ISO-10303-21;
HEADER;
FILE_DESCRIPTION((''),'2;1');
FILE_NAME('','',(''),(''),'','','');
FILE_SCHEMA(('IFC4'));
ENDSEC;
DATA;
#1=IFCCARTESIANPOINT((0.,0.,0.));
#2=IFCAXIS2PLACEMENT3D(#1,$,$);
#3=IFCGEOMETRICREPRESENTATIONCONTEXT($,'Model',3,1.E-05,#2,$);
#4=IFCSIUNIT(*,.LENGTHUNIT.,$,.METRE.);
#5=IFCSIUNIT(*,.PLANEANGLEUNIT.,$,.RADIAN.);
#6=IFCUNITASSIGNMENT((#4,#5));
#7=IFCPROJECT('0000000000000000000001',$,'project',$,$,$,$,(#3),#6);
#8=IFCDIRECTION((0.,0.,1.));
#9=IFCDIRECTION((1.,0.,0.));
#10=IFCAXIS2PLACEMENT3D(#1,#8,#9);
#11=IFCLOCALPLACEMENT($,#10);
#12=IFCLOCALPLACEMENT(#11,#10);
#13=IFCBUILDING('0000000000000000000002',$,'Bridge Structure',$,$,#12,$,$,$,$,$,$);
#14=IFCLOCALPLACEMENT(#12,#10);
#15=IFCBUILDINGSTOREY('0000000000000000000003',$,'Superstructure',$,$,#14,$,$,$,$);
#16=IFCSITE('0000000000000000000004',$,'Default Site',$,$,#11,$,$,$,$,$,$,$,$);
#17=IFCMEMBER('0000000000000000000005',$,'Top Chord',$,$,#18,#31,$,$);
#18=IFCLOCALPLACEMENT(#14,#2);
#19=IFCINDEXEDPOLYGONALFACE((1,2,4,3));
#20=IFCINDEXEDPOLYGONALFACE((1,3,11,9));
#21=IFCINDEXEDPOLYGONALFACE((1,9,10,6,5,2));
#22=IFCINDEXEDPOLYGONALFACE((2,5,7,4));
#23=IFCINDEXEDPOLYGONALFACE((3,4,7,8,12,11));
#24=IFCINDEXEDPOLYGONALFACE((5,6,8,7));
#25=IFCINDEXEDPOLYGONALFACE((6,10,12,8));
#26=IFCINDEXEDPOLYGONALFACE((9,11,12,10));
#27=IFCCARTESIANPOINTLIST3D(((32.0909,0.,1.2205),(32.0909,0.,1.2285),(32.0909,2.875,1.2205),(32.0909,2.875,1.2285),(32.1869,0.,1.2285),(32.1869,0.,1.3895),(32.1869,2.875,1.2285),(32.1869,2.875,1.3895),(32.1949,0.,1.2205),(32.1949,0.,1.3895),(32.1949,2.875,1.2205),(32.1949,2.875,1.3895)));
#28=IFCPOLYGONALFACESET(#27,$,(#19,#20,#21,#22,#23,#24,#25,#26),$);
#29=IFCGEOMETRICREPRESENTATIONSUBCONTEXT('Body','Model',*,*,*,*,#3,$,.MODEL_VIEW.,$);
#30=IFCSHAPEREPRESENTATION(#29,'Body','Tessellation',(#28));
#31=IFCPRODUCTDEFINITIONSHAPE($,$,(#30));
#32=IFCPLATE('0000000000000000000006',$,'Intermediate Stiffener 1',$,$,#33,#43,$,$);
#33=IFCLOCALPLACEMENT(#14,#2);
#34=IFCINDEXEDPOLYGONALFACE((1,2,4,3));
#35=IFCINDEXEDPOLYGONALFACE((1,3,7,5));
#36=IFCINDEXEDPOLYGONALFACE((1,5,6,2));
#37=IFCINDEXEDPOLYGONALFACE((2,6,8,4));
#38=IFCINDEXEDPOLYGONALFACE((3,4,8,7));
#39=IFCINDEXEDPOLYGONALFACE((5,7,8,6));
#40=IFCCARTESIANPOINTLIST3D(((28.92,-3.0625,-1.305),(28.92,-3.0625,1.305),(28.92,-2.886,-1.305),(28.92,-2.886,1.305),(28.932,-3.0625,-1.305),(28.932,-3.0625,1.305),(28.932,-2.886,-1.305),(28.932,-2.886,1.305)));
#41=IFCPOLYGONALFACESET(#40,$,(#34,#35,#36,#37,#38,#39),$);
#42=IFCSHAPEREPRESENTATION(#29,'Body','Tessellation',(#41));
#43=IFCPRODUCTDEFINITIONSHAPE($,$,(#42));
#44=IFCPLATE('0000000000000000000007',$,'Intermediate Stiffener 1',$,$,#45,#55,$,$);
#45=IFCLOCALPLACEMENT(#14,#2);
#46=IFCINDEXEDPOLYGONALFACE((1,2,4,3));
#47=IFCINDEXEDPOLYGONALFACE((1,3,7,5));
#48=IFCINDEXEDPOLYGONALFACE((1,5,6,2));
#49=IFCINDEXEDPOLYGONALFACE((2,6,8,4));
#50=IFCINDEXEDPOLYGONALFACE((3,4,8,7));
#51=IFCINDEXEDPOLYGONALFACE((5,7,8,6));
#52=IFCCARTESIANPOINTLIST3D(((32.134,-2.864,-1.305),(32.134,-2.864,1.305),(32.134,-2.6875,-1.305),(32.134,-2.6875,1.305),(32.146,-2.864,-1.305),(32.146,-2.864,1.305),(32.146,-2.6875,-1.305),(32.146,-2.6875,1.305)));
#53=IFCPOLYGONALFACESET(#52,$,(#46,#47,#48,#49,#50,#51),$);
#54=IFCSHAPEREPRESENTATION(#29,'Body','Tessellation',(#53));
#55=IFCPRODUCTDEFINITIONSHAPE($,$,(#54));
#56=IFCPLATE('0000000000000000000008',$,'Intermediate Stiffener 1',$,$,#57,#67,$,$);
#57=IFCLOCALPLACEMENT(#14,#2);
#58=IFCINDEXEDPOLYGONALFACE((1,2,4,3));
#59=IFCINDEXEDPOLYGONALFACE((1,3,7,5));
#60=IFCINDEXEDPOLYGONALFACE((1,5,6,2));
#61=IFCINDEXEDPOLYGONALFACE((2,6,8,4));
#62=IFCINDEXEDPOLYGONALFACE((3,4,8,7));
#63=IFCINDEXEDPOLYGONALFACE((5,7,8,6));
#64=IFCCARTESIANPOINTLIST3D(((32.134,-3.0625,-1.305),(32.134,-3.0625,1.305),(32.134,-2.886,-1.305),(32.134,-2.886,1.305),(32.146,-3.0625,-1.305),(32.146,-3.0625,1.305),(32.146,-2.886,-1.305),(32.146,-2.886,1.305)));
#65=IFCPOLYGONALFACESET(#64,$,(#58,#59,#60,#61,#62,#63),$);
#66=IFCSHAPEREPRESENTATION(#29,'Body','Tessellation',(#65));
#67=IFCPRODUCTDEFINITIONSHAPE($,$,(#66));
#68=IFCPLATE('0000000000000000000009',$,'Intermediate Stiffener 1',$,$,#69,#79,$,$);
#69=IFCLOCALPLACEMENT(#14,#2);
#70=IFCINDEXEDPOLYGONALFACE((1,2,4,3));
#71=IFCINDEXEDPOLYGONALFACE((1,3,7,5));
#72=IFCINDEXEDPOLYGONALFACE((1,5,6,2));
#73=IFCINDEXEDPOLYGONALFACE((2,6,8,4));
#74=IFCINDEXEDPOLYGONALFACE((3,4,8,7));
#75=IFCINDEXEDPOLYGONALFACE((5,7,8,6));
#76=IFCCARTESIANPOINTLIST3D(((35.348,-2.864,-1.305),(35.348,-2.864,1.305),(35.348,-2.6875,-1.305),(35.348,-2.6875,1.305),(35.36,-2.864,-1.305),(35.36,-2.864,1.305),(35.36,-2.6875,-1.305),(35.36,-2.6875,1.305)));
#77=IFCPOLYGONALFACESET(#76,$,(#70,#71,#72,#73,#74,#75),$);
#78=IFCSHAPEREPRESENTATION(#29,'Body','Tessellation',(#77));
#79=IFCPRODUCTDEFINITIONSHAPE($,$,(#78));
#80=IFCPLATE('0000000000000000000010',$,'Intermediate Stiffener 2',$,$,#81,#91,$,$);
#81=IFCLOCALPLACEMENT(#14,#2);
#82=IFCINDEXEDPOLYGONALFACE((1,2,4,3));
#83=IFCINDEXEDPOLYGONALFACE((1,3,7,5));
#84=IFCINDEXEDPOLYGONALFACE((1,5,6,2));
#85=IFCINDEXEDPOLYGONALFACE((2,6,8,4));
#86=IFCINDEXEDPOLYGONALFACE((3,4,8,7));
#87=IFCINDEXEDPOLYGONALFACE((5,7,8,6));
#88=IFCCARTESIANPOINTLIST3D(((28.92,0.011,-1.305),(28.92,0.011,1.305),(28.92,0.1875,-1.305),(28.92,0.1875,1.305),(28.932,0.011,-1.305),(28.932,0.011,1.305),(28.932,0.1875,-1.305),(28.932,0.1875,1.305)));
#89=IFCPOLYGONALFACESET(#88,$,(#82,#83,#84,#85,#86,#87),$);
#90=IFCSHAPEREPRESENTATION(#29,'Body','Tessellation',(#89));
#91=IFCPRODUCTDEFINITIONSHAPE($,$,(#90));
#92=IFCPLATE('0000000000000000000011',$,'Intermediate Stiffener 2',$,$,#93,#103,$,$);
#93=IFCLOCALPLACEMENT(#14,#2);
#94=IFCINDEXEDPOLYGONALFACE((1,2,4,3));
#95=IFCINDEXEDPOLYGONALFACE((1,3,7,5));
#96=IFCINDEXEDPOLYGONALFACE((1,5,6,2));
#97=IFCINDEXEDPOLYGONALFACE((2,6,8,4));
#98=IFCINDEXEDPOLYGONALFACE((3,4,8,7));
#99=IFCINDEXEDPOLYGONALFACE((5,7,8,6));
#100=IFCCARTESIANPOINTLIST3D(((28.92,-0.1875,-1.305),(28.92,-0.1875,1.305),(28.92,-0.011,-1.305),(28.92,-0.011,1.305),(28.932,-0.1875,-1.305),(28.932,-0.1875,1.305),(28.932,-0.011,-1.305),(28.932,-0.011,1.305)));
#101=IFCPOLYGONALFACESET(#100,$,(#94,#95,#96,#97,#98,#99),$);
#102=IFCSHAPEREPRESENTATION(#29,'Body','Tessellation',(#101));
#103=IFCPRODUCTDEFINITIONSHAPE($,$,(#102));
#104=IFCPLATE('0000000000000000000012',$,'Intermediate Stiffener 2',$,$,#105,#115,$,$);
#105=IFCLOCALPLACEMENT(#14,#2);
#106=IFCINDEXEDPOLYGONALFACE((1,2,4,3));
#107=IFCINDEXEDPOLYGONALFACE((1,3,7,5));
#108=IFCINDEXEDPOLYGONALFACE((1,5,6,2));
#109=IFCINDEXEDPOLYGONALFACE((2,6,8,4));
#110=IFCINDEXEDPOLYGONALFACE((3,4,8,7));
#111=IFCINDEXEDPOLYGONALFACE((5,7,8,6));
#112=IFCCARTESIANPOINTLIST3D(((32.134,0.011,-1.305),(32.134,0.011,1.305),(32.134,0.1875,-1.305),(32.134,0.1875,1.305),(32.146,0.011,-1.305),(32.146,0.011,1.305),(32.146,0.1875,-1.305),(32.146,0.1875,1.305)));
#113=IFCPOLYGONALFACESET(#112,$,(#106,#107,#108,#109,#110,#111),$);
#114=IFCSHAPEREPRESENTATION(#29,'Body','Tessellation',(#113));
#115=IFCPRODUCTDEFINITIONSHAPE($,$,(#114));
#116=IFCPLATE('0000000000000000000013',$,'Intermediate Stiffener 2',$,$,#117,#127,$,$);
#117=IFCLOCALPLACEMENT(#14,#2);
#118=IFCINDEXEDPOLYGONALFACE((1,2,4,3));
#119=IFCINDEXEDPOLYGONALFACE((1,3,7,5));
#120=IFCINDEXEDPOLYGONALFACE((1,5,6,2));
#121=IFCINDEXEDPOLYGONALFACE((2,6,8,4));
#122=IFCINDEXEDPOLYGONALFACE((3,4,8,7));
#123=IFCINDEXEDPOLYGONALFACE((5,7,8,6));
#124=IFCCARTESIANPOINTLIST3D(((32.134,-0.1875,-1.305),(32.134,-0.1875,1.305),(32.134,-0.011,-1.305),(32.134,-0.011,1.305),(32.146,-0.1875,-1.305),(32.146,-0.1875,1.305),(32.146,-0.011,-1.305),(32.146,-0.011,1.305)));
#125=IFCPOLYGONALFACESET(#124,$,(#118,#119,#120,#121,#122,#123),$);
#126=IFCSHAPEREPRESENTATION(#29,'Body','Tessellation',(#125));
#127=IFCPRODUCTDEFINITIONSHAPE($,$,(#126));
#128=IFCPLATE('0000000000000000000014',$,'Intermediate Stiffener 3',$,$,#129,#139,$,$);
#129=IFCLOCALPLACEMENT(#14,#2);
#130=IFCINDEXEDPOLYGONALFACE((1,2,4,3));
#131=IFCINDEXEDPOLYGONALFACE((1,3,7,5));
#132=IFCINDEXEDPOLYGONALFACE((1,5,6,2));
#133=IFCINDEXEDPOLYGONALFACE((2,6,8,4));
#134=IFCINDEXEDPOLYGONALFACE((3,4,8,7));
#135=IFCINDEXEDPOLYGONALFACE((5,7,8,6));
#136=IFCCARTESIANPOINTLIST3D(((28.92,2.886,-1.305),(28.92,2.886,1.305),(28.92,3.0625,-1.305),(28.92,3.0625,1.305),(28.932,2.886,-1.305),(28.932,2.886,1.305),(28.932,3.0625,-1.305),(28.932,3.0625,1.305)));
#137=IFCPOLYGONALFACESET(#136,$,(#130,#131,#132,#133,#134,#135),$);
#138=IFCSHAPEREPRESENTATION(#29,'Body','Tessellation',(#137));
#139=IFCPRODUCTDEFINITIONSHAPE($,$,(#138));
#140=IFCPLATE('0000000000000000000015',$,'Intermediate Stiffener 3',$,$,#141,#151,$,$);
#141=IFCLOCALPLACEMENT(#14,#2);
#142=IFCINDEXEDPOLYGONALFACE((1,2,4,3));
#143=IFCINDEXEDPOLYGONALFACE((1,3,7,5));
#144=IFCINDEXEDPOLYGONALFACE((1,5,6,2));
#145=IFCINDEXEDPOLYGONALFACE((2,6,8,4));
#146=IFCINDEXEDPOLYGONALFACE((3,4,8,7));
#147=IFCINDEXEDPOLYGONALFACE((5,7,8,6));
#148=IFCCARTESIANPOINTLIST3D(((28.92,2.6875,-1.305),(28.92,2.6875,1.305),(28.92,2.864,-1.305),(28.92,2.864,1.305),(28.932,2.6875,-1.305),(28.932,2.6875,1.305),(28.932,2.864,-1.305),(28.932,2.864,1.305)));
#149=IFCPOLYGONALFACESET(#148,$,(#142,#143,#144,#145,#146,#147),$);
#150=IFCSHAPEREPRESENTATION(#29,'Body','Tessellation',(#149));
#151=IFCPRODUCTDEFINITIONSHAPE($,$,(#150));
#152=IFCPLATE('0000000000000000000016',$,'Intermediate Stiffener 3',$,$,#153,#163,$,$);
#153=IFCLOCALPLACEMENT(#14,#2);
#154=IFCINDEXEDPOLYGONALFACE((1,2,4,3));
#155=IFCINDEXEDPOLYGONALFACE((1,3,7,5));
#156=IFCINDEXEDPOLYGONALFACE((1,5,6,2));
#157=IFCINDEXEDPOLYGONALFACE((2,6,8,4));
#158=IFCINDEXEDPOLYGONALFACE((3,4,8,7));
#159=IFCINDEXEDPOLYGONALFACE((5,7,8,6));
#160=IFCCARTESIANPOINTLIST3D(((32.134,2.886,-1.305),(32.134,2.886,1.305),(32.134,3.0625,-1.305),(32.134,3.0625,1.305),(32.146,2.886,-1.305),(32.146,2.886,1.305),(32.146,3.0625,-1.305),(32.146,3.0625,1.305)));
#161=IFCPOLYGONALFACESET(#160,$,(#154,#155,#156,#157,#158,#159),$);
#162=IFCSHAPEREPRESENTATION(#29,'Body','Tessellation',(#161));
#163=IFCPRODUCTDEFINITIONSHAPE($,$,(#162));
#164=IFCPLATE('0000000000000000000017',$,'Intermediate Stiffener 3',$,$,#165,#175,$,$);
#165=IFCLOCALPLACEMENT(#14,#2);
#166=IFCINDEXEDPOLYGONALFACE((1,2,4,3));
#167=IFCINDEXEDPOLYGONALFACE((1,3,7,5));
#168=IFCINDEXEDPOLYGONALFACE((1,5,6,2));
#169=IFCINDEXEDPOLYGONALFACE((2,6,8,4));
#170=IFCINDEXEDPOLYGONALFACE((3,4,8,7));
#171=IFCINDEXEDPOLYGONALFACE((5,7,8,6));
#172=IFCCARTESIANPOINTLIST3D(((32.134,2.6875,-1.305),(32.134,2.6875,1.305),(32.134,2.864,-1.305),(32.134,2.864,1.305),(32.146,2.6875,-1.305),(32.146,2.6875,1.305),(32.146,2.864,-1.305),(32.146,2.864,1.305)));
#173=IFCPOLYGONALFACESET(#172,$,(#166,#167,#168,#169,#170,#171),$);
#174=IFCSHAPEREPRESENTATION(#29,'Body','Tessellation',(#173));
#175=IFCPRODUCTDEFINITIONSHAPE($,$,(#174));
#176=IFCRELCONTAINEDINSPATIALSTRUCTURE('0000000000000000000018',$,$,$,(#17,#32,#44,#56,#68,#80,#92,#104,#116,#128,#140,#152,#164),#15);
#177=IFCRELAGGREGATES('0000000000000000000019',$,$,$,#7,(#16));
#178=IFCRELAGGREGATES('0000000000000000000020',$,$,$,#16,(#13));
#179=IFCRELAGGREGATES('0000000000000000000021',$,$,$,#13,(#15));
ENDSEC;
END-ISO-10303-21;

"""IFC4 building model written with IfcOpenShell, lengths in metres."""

from ifc_helpers import new_model, si_unit, frame, origin, origin_with_axes, origin_2d_with_axis, place, context, subcontext, project, spatial, rectangle, l_section, extrude, element, save


model = new_model("IFC4")

# Units and contexts
model_context = context("Model", 3, precision=1e-05, world=origin())
body_context = subcontext(model_context, "Body", "Model", "MODEL_VIEW")
ifc_project = project(units=[si_unit("LENGTHUNIT", "METRE"), si_unit("PLANEANGLEUNIT", "RADIAN")], contexts=[model_context])

# Site, building, storey
site_placement = place(None, origin_with_axes())
site = spatial("IfcSite", under=ifc_project, at=site_placement, Name="Default Site")
building_placement = place(site_placement, origin_with_axes())
building = spatial("IfcBuilding", under=site, at=building_placement, Name="Bridge Structure")
storey_placement = place(building_placement, origin_with_axes())
storey = spatial("IfcBuildingStorey", under=building, at=storey_placement, Name="Superstructure")

# Member
for number, where, z_axis, x_axis, name in (
    (1, (32.1429, 0.0, 1.305), (0.0, 1.0, 0.0), (-1.0, 0.0, 0.0), "Top Chord"),
):
    element("IfcMember", number, at=place(storey_placement, frame(where, z_axis=z_axis, x_axis=x_axis)), inside=storey, Name=name, context=body_context, shape_type="SweptSolid", body=[
        extrude(l_section(Depth=0.169, Width=0.104, Thickness=0.008, at=origin_2d_with_axis()), origin_with_axes(), (0.0, 0.0, 1.0), 2.875),
    ])

# Plates
for number, where, z_axis, x_axis, name in (
    (2, (28.926, -2.9743, -1.305), (0.0, 0.0, 1.0), (1.0, 0.0, 0.0), "Intermediate Stiffener 1"),
    (3, (32.14, -2.7757, -1.305), (0.0, 0.0, 1.0), (1.0, 0.0, 0.0), "Intermediate Stiffener 1"),
    (4, (32.14, -2.9743, -1.305), (0.0, 0.0, 1.0), (1.0, 0.0, 0.0), "Intermediate Stiffener 1"),
    (5, (35.354, -2.7757, -1.305), (0.0, 0.0, 1.0), (1.0, 0.0, 0.0), "Intermediate Stiffener 1"),
    (6, (28.926, 0.0993, -1.305), (0.0, 0.0, 1.0), (1.0, 0.0, 0.0), "Intermediate Stiffener 2"),
    (7, (28.926, -0.0993, -1.305), (0.0, 0.0, 1.0), (1.0, 0.0, 0.0), "Intermediate Stiffener 2"),
    (8, (32.14, 0.0993, -1.305), (0.0, 0.0, 1.0), (1.0, 0.0, 0.0), "Intermediate Stiffener 2"),
    (9, (32.14, -0.0993, -1.305), (0.0, 0.0, 1.0), (1.0, 0.0, 0.0), "Intermediate Stiffener 2"),
    (10, (28.926, 2.9743, -1.305), (0.0, 0.0, 1.0), (1.0, 0.0, 0.0), "Intermediate Stiffener 3"),
    (11, (28.926, 2.7757, -1.305), (0.0, 0.0, 1.0), (1.0, 0.0, 0.0), "Intermediate Stiffener 3"),
    (12, (32.14, 2.9743, -1.305), (0.0, 0.0, 1.0), (1.0, 0.0, 0.0), "Intermediate Stiffener 3"),
    (13, (32.14, 2.7757, -1.305), (0.0, 0.0, 1.0), (1.0, 0.0, 0.0), "Intermediate Stiffener 3"),
):
    element("IfcPlate", number, at=place(storey_placement, frame(where, z_axis=z_axis, x_axis=x_axis)), inside=storey, Name=name, context=body_context, shape_type="SweptSolid", body=[
        extrude(rectangle(XDim=0.012, YDim=0.1765, at=origin_2d_with_axis()), origin_with_axes(), (0.0, 0.0, 1.0), 2.61),
    ])

save(model, "model.ifc")
